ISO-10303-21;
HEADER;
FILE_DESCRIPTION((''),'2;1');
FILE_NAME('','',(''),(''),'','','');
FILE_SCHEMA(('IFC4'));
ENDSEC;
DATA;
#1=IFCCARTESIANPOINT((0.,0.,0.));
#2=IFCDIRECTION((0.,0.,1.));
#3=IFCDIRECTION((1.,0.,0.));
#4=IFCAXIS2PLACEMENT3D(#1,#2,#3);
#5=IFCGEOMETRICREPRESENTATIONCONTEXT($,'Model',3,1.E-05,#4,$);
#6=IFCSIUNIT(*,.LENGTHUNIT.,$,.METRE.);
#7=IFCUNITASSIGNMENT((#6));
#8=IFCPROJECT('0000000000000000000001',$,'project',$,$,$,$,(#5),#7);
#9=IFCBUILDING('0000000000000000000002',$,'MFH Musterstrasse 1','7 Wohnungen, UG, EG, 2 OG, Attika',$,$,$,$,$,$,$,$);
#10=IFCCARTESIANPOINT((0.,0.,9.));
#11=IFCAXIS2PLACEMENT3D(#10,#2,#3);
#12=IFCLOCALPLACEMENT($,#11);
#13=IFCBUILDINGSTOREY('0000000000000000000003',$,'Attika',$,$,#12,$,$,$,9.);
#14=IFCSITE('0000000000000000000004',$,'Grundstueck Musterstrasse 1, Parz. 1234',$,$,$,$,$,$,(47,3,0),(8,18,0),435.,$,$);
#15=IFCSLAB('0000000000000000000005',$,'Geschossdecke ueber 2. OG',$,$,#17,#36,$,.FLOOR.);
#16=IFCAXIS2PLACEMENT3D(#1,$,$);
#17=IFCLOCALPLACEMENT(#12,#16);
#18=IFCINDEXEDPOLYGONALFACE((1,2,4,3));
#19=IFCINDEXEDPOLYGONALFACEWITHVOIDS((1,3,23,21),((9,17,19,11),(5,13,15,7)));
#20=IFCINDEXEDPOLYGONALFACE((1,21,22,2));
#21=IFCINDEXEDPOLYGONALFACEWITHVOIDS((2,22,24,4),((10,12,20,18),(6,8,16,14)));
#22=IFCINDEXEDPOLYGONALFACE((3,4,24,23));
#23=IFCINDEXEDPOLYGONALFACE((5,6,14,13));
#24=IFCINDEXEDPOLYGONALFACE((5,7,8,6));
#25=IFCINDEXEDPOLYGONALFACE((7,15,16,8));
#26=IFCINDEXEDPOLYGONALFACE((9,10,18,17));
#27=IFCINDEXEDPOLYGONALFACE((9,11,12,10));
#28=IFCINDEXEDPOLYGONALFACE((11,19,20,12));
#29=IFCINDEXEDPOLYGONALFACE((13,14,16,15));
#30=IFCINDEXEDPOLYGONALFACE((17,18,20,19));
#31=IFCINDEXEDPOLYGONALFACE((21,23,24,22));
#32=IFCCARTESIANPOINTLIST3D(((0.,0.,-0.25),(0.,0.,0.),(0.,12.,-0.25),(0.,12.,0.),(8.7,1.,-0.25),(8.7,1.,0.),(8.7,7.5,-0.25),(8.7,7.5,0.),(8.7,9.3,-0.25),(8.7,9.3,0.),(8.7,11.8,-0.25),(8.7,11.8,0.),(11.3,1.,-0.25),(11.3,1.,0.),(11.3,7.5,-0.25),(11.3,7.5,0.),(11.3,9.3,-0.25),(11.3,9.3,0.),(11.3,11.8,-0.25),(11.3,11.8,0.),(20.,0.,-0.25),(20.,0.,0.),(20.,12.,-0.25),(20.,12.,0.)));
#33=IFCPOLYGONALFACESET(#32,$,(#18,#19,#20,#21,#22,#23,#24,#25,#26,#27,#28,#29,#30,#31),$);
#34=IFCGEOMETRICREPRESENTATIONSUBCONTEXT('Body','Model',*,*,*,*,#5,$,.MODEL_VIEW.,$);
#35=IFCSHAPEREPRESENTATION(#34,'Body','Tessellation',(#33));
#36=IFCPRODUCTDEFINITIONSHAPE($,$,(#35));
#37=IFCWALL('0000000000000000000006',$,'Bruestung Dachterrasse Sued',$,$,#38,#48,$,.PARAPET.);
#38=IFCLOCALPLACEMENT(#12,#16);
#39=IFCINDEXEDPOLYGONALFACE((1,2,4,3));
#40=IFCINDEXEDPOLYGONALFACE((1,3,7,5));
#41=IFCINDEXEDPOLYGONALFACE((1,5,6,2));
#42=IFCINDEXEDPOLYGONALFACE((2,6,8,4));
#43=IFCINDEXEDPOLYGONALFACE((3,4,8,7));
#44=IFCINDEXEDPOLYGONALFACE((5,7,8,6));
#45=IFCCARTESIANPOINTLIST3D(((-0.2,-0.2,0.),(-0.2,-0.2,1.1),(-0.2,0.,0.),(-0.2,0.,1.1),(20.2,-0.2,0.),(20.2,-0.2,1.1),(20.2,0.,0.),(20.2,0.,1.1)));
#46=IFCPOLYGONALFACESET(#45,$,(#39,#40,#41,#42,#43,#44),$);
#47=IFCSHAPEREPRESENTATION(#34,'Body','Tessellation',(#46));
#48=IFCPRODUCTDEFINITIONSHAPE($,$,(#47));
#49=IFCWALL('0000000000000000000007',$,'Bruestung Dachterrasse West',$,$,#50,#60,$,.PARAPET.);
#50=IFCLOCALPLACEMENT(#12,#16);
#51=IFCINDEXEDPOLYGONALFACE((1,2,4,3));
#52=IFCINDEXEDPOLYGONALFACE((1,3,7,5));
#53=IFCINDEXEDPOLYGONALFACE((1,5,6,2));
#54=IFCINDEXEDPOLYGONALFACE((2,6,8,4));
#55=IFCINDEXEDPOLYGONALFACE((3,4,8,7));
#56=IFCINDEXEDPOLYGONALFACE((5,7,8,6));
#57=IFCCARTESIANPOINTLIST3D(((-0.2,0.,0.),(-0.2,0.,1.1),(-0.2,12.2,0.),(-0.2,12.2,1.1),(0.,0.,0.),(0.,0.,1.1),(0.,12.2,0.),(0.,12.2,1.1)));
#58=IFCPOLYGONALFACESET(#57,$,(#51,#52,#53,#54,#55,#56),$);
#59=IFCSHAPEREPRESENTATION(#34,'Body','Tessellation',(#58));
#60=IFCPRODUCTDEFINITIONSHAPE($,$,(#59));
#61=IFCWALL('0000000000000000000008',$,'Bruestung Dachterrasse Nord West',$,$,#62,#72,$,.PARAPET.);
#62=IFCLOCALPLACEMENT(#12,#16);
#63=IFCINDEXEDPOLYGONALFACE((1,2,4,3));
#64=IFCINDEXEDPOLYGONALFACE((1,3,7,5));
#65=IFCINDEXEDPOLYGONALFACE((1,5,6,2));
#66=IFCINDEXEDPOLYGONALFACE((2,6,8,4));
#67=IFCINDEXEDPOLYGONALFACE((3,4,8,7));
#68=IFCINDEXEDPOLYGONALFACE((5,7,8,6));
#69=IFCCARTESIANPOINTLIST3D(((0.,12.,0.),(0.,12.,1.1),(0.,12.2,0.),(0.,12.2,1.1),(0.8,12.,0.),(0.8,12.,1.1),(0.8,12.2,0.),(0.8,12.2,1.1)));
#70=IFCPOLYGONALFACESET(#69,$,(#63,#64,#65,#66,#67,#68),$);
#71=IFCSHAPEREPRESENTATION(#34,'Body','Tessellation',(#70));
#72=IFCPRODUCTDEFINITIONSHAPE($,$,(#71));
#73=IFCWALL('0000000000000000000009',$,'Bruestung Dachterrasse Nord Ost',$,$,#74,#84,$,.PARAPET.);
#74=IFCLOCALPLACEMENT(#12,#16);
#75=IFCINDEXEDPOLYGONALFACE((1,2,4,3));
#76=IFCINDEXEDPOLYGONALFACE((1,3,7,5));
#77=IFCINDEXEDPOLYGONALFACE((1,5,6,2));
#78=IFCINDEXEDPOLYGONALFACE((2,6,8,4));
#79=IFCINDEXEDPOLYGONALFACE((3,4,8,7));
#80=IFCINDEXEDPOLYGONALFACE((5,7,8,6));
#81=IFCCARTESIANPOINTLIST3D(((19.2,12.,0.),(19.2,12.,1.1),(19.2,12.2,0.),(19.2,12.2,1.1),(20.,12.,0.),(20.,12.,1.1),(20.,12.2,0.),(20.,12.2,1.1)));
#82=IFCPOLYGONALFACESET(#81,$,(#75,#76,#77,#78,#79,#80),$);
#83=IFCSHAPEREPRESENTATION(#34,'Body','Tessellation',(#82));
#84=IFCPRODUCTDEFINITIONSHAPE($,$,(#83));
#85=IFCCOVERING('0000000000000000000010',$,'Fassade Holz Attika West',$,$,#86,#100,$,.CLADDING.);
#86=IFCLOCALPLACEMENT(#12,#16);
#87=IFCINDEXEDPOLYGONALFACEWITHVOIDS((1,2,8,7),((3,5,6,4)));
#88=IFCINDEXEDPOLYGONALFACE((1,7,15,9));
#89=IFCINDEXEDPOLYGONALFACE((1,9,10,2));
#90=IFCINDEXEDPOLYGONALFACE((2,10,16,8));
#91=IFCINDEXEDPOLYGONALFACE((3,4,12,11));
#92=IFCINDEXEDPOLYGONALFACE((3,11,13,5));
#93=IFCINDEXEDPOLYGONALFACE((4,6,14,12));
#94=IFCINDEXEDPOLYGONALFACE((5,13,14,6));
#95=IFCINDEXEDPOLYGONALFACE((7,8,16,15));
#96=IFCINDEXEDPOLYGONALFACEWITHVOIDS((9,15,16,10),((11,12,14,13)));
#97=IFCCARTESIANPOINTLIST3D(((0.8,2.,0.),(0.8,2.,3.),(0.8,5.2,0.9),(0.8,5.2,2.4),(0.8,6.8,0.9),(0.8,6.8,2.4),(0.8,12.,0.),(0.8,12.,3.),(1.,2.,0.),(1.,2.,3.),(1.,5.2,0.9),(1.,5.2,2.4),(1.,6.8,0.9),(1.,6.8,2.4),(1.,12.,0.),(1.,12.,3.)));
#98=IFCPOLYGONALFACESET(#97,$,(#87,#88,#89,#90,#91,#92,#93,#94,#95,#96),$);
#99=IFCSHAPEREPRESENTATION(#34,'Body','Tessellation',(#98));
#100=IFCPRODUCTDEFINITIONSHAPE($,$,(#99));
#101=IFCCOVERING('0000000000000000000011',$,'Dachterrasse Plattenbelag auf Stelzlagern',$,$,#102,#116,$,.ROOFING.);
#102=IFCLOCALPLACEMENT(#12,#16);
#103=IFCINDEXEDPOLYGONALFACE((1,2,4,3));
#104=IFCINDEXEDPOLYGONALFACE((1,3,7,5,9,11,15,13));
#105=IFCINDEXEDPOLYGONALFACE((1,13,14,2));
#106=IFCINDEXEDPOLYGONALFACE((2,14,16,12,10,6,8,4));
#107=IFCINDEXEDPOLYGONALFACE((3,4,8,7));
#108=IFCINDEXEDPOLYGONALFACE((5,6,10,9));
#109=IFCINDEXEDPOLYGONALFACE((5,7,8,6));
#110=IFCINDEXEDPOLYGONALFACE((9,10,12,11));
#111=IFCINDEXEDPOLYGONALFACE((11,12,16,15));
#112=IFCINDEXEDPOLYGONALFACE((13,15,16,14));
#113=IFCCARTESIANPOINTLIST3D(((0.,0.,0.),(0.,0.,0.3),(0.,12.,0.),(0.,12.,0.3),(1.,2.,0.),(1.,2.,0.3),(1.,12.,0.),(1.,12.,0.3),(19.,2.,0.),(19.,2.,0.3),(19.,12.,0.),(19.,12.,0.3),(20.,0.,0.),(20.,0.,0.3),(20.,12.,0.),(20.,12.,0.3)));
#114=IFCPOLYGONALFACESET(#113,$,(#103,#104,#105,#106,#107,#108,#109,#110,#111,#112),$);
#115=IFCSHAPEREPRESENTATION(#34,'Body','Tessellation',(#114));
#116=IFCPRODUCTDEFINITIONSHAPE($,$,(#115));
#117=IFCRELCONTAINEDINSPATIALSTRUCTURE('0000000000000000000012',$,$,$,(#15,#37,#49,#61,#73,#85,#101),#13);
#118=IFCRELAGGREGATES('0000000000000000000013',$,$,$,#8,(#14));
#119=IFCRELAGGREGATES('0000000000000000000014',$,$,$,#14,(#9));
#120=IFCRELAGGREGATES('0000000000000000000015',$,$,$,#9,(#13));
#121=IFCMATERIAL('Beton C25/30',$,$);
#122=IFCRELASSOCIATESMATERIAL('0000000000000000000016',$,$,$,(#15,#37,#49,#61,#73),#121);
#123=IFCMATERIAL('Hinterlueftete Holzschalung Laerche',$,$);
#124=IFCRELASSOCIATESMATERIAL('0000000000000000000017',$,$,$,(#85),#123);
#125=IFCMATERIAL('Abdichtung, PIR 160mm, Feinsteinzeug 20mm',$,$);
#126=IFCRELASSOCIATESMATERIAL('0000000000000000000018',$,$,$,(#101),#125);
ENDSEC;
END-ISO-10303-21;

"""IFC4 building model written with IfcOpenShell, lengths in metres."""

from ifc_helpers import new_model, si_unit, frame, frame_2d, origin_with_axes, place, context, subcontext, project, spatial, polyline, rectangle, outline, extrude, material, element, save


model = new_model("IFC4")

# Units and contexts
model_context = context("Model", 3, precision=1e-05, world=origin_with_axes())
body_context = subcontext(model_context, "Body", "Model", "MODEL_VIEW")
ifc_project = project(units=[si_unit("LENGTHUNIT", "METRE")], contexts=[model_context])

# Site, building, storey
site = spatial("IfcSite", under=ifc_project, Name="Grundstueck Musterstrasse 1, Parz. 1234", RefLatitude=(47, 3, 0), RefLongitude=(8, 18, 0), RefElevation=435.0)
building = spatial("IfcBuilding", under=site, Name="MFH Musterstrasse 1", Description="7 Wohnungen, UG, EG, 2 OG, Attika")
storey_placement = place(None, frame((0.0, 0.0, 9.0), z_axis=(0.0, 0.0, 1.0), x_axis=(1.0, 0.0, 0.0)))
storey = spatial("IfcBuildingStorey", under=building, at=storey_placement, Name="Attika", Elevation=9.0)

# Slab, openings
ifc_material_1 = material(Name="Beton C25/30")
slab_placement = place(storey_placement, frame((0.0, 0.0, -0.25), z_axis=(0.0, 0.0, 1.0), x_axis=(1.0, 0.0, 0.0)))
slab = element("IfcSlab", 1, at=slab_placement, inside=storey, material=ifc_material_1, Name="Geschossdecke ueber 2. OG", PredefinedType="FLOOR", context=body_context, shape_type="SweptSolid", body=[
    extrude(outline(polyline([(0.0, 0.0), (20.0, 0.0), (20.0, 12.0), (0.0, 12.0), (0.0, 0.0)])), origin_with_axes(), (0.0, 0.0, 1.0), 0.25),
])
opening_1_placement = place(slab_placement, frame((8.7, 1.0, -0.01), z_axis=(0.0, 0.0, 1.0), x_axis=(1.0, 0.0, 0.0)))
element("IfcOpeningElement", 2, at=opening_1_placement, cuts=slab, context=body_context, shape_type="SweptSolid", body=[
    extrude(rectangle(XDim=2.6, YDim=6.5, at=frame_2d((1.3, 3.25))), origin_with_axes(), (0.0, 0.0, 1.0), 0.27),
])
opening_2_placement = place(slab_placement, frame((8.7, 9.3, -0.01), z_axis=(0.0, 0.0, 1.0), x_axis=(1.0, 0.0, 0.0)))
element("IfcOpeningElement", 3, at=opening_2_placement, cuts=slab, context=body_context, shape_type="SweptSolid", body=[
    extrude(rectangle(XDim=2.6, YDim=2.5, at=frame_2d((1.3, 1.25))), origin_with_axes(), (0.0, 0.0, 1.0), 0.27),
])

# Walls
wall_1_placement = place(storey_placement, frame((-0.2, -0.2, 0.0), z_axis=(0.0, 0.0, 1.0), x_axis=(1.0, 0.0, 0.0)))
element("IfcWall", 4, at=wall_1_placement, inside=storey, material=ifc_material_1, Name="Bruestung Dachterrasse Sued", PredefinedType="PARAPET", context=body_context, shape_type="SweptSolid", body=[
    extrude(rectangle(XDim=20.4, YDim=0.2, at=frame_2d((10.2, 0.1))), origin_with_axes(), (0.0, 0.0, 1.0), 1.1),
])
wall_2_placement = place(storey_placement, frame((-0.2, 0.0, 0.0), z_axis=(0.0, 0.0, 1.0), x_axis=(1.0, 0.0, 0.0)))
element("IfcWall", 5, at=wall_2_placement, inside=storey, material=ifc_material_1, Name="Bruestung Dachterrasse West", PredefinedType="PARAPET", context=body_context, shape_type="SweptSolid", body=[
    extrude(rectangle(XDim=0.2, YDim=12.2, at=frame_2d((0.1, 6.1))), origin_with_axes(), (0.0, 0.0, 1.0), 1.1),
])
wall_3_placement = place(storey_placement, frame((-0.2, 0.0, 0.0), z_axis=(0.0, 0.0, 1.0), x_axis=(1.0, 0.0, 0.0)))
element("IfcWall", 6, at=wall_3_placement, inside=storey, material=ifc_material_1, Name="Bruestung Dachterrasse Nord West", PredefinedType="PARAPET", context=body_context, shape_type="SweptSolid", body=[
    extrude(rectangle(XDim=0.8, YDim=0.2, at=frame_2d((0.6, 12.1))), origin_with_axes(), (0.0, 0.0, 1.0), 1.1),
])
wall_4_placement = place(storey_placement, frame((-0.2, 0.0, 0.0), z_axis=(0.0, 0.0, 1.0), x_axis=(1.0, 0.0, 0.0)))
element("IfcWall", 7, at=wall_4_placement, inside=storey, material=ifc_material_1, Name="Bruestung Dachterrasse Nord Ost", PredefinedType="PARAPET", context=body_context, shape_type="SweptSolid", body=[
    extrude(rectangle(XDim=0.8, YDim=0.2, at=frame_2d((19.8, 12.1))), origin_with_axes(), (0.0, 0.0, 1.0), 1.1),
])

# Shared definitions
ifc_material_2 = material(Name="Hinterlueftete Holzschalung Laerche")

# Covering, opening
covering_1_placement = place(storey_placement, frame((0.8, 2.0, 0.0), z_axis=(0.0, 0.0, 1.0), x_axis=(1.0, 0.0, 0.0)))
covering_1 = element("IfcCovering", 8, at=covering_1_placement, inside=storey, material=ifc_material_2, Name="Fassade Holz Attika West", PredefinedType="CLADDING", context=body_context, shape_type="SweptSolid", body=[
    extrude(rectangle(XDim=0.2, YDim=10.0, at=frame_2d((0.1, 5.0))), origin_with_axes(), (0.0, 0.0, 1.0), 3.0),
])
opening_3_placement = place(covering_1_placement, frame((-0.01, 3.2, 0.9), z_axis=(0.0, 0.0, 1.0), x_axis=(1.0, 0.0, 0.0)))
element("IfcOpeningElement", 9, at=opening_3_placement, cuts=covering_1, context=body_context, shape_type="SweptSolid", body=[
    extrude(rectangle(XDim=0.42, YDim=1.6, at=frame_2d((0.21, 0.8))), origin_with_axes(), (0.0, 0.0, 1.0), 1.5),
])

# Covering
ifc_material_3 = material(Name="Abdichtung, PIR 160mm, Feinsteinzeug 20mm")
covering_2_placement = place(storey_placement, origin_with_axes())
element("IfcCovering", 10, at=covering_2_placement, inside=storey, material=ifc_material_3, Name="Dachterrasse Plattenbelag auf Stelzlagern", PredefinedType="ROOFING", context=body_context, shape_type="SweptSolid", body=[
    extrude(outline(polyline([(0.0, 0.0), (20.0, 0.0), (20.0, 12.0), (19.0, 12.0), (19.0, 2.0), (1.0, 2.0), (1.0, 12.0), (0.0, 12.0), (0.0, 0.0)])), origin_with_axes(), (0.0, 0.0, 1.0), 0.3),
])

save(model, "model.ifc")
